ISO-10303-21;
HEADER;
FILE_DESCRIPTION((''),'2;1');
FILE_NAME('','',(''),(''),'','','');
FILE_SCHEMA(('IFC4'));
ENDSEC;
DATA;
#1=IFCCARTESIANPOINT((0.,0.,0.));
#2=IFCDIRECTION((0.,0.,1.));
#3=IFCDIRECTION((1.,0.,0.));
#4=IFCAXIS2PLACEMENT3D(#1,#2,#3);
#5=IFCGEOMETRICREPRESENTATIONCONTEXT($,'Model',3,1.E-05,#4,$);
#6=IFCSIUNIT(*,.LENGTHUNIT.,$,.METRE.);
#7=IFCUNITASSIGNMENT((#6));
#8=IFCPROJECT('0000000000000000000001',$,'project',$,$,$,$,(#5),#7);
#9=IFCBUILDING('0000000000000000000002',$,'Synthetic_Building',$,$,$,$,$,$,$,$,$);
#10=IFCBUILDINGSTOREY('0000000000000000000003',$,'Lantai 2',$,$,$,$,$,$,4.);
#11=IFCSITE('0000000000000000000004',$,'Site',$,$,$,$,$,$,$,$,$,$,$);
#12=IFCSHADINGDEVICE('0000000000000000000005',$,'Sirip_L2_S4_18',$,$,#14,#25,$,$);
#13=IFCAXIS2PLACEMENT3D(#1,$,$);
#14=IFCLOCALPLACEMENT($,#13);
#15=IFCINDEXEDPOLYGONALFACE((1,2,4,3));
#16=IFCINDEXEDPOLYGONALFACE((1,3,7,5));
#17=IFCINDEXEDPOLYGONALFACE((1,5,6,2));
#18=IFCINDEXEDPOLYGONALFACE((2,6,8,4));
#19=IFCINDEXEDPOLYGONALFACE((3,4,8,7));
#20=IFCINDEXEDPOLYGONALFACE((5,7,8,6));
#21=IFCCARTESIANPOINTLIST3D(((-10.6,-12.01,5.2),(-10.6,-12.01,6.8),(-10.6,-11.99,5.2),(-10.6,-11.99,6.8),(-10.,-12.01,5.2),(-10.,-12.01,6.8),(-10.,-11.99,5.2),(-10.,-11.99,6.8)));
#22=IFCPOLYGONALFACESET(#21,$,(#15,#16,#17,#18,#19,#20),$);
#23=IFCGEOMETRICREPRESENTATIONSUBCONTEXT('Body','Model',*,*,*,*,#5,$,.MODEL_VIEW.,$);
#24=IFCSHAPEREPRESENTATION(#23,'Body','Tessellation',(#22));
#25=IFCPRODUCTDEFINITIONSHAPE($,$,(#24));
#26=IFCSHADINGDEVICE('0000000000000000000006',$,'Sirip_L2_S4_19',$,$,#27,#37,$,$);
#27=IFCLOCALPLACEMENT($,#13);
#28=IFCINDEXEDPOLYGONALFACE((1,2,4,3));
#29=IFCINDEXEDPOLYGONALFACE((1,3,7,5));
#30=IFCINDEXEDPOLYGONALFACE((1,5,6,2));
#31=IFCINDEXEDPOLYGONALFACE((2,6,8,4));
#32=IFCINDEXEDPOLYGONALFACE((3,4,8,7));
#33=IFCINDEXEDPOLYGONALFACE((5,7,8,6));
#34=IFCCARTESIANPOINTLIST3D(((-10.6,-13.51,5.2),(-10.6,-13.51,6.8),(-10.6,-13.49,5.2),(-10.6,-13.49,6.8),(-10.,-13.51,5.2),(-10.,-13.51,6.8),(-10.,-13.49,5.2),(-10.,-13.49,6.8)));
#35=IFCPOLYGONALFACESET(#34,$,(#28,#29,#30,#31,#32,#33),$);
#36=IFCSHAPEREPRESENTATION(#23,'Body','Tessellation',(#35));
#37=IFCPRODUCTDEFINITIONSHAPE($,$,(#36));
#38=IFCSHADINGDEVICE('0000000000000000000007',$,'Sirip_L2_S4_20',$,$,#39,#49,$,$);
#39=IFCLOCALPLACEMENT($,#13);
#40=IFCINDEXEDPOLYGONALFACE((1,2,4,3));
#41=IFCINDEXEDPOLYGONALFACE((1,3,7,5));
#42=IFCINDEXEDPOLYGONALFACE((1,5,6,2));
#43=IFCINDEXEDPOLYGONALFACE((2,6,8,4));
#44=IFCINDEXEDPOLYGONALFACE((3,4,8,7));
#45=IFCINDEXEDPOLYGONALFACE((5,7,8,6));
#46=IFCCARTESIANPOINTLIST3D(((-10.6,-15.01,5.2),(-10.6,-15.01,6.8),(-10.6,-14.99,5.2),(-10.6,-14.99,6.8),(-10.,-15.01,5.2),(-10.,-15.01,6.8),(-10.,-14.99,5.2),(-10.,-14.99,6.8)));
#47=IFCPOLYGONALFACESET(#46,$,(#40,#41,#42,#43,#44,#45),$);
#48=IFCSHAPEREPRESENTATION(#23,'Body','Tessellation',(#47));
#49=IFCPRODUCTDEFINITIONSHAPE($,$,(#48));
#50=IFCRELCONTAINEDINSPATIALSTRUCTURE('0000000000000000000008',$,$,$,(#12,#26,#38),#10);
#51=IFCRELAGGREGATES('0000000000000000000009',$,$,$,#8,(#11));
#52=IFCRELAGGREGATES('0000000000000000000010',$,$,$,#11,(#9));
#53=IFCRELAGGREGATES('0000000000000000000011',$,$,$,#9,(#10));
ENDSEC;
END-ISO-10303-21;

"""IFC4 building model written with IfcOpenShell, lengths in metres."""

from ifc_helpers import new_model, si_unit, frame, origin_with_axes, place, context, subcontext, project, spatial, polyline, outline, extrude, element, save


model = new_model("IFC4")

# Units and contexts
model_context = context("Model", 3, precision=1e-05, world=origin_with_axes())
body_context = subcontext(model_context, "Body", "Model", "MODEL_VIEW")
ifc_project = project(units=[si_unit("LENGTHUNIT", "METRE")], contexts=[model_context])

# Site, building, storey
site = spatial("IfcSite", under=ifc_project, Name="Site")
building = spatial("IfcBuilding", under=site, Name="Synthetic_Building")
storey = spatial("IfcBuildingStorey", under=building, Name="Lantai 2", Elevation=4.0)

# Shading devices
shading_device_1_placement = place(None, origin_with_axes())
element("IfcShadingDevice", 1, at=shading_device_1_placement, inside=storey, Name="Sirip_L2_S4_18", context=body_context, shape_type="SweptSolid", body=[
    extrude(outline(polyline([(-10.0, -11.99), (-10.0, -12.01), (-10.6, -12.01), (-10.6, -11.99), (-10.0, -11.99)])), frame((0.0, 0.0, 5.2), z_axis=(0.0, 0.0, 1.0), x_axis=(1.0, 0.0, 0.0)), (0.0, 0.0, 1.0), 1.6),
])
shading_device_2_placement = place(None, origin_with_axes())
element("IfcShadingDevice", 2, at=shading_device_2_placement, inside=storey, Name="Sirip_L2_S4_19", context=body_context, shape_type="SweptSolid", body=[
    extrude(outline(polyline([(-10.0, -13.49), (-10.0, -13.51), (-10.6, -13.51), (-10.6, -13.49), (-10.0, -13.49)])), frame((0.0, 0.0, 5.2), z_axis=(0.0, 0.0, 1.0), x_axis=(1.0, 0.0, 0.0)), (0.0, 0.0, 1.0), 1.6),
])
shading_device_3_placement = place(None, origin_with_axes())
element("IfcShadingDevice", 3, at=shading_device_3_placement, inside=storey, Name="Sirip_L2_S4_20", context=body_context, shape_type="SweptSolid", body=[
    extrude(outline(polyline([(-10.0, -14.99), (-10.0, -15.01), (-10.6, -15.01), (-10.6, -14.99), (-10.0, -14.99)])), frame((0.0, 0.0, 5.2), z_axis=(0.0, 0.0, 1.0), x_axis=(1.0, 0.0, 0.0)), (0.0, 0.0, 1.0), 1.6),
])

save(model, "model.ifc")
